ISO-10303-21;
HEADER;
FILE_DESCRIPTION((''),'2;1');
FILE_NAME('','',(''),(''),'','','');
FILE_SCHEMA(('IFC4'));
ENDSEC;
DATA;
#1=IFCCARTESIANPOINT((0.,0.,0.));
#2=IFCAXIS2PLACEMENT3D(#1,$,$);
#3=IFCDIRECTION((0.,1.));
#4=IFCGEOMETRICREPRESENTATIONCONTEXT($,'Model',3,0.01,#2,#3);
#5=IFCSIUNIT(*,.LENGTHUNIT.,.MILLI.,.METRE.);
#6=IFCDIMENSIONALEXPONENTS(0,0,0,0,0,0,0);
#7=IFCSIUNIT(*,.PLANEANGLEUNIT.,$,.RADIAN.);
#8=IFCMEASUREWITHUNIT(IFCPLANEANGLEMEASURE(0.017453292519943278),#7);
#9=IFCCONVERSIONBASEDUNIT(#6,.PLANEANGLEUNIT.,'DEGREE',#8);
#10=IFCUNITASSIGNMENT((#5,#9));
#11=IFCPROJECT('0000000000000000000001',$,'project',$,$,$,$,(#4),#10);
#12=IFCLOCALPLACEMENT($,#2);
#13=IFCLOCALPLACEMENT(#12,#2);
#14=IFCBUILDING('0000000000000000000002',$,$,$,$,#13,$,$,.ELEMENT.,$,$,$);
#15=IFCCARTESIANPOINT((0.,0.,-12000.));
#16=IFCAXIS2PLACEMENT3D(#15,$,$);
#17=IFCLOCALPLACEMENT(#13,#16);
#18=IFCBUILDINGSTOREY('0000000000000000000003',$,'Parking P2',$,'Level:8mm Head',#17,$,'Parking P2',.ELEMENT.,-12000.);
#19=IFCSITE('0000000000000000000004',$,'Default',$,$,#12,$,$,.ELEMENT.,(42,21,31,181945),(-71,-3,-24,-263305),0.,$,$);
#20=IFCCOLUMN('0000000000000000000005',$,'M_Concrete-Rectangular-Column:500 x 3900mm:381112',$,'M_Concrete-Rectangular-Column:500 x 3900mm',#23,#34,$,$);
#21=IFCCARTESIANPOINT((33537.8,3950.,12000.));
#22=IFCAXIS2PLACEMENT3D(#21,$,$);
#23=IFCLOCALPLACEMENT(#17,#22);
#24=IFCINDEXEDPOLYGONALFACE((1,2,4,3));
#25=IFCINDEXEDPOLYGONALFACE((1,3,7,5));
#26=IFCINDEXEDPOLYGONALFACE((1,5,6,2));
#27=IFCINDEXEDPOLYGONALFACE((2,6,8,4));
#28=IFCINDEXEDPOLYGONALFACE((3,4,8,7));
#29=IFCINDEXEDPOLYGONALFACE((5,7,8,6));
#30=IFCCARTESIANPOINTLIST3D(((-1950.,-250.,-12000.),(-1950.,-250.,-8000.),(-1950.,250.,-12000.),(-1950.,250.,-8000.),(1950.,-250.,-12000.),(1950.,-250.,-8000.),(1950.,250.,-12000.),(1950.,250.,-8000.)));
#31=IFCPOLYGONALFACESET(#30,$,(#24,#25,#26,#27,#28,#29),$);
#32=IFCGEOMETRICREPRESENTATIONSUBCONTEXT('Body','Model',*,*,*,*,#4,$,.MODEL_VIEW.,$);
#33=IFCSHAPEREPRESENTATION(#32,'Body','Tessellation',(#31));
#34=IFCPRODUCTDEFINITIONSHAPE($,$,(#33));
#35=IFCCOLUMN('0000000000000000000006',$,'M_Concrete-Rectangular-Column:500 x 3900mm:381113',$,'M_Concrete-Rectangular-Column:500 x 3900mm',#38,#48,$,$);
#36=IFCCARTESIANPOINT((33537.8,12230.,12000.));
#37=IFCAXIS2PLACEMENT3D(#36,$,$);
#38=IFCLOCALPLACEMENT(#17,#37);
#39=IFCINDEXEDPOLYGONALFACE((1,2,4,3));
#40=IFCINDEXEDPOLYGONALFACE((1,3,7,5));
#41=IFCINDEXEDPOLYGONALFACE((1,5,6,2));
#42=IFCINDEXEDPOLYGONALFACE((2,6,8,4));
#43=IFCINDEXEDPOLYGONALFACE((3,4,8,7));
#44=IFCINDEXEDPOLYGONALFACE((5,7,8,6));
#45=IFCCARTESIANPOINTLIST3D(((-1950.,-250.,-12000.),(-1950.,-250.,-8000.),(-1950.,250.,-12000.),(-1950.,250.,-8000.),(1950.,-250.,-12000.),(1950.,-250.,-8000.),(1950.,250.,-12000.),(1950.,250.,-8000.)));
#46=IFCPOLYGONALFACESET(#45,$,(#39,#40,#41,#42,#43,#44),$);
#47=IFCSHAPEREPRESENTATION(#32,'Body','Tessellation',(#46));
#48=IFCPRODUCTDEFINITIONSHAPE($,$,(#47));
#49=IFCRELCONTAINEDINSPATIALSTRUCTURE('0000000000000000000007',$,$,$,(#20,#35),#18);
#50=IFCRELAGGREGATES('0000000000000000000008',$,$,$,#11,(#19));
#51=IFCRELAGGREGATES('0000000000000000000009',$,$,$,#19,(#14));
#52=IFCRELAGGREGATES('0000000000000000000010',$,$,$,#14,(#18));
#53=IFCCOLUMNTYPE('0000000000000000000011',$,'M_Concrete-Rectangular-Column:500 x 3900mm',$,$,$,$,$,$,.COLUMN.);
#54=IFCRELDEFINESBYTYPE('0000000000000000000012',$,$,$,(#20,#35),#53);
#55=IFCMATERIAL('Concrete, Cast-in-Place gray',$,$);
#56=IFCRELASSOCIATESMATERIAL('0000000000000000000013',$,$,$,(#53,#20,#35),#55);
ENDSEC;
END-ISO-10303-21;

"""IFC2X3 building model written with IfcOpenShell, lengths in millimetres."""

from ifc_helpers import new_model, entity, si_unit, converted_unit, direction, frame, origin, origin_2d_with_axis, place, context, subcontext, project, spatial, rectangle, extrude, source, transform, mapped, material, type_object, type_shapes, element, save


model = new_model("IFC2X3")

# Units and contexts
model_context = context("Model", 3, precision=0.01, world=origin(), true_north=direction((0.0, 1.0)))
body_context = subcontext(model_context, "Body", "Model", "MODEL_VIEW")
ifc_project = project(units=[si_unit("LENGTHUNIT", "METRE", prefix="MILLI"), converted_unit("PLANEANGLEUNIT", "DEGREE", entity("IfcPlaneAngleMeasure", 0.017453292519943278), si_unit("PLANEANGLEUNIT", "RADIAN"), dimensions=[0, 0, 0, 0, 0, 0, 0])], contexts=[model_context])

# Site, building, storey
site_placement = place(None, origin())
site = spatial("IfcSite", under=ifc_project, at=site_placement, Name="Default", CompositionType="ELEMENT", RefLatitude=(42, 21, 31, 181945), RefLongitude=(-71, -3, -24, -263305), RefElevation=0.0)
building_placement = place(site_placement, origin())
building = spatial("IfcBuilding", under=site, at=building_placement, CompositionType="ELEMENT")
storey_placement = place(building_placement, frame((0.0, 0.0, -12000.0)))
storey = spatial("IfcBuildingStorey", under=building, at=storey_placement, Name="Parking P2", ObjectType="Level:8mm Head", LongName="Parking P2", CompositionType="ELEMENT", Elevation=-12000.0)

# Columns
ifc_material_1 = material(Name="Concrete, Cast-in-Place gray")
column_type = type_object("IfcColumnType", Name="M_Concrete-Rectangular-Column:500 x 3900mm", PredefinedType="COLUMN", material=ifc_material_1)
shared_shape = source(origin(), body_context, "Body", "SweptSolid", [
    extrude(rectangle(XDim=3900.0, YDim=500.0, at=origin_2d_with_axis()), frame((0.0, 0.0, -12000.0), z_axis=(0.0, 0.0, 1.0), x_axis=(-1.0, 0.0, 0.0)), (0.0, 0.0, 1.0), 4000.0),
])
type_shapes(column_type, [shared_shape])
for number, where, name in (
    (1, (33537.8, 3950.0, 12000.0), "M_Concrete-Rectangular-Column:500 x 3900mm:381112"),
    (2, (33537.8, 12230.0, 12000.0), "M_Concrete-Rectangular-Column:500 x 3900mm:381113"),
):
    element("IfcColumn", number, at=place(storey_placement, frame(where)), inside=storey, type_object=column_type, material=ifc_material_1, Name=name, ObjectType="M_Concrete-Rectangular-Column:500 x 3900mm", context=body_context, shape_type="MappedRepresentation", body=[
        mapped(shared_shape, transform((0.0, 0.0, 0.0), scale=1.0)),
    ])

save(model, "model.ifc")
